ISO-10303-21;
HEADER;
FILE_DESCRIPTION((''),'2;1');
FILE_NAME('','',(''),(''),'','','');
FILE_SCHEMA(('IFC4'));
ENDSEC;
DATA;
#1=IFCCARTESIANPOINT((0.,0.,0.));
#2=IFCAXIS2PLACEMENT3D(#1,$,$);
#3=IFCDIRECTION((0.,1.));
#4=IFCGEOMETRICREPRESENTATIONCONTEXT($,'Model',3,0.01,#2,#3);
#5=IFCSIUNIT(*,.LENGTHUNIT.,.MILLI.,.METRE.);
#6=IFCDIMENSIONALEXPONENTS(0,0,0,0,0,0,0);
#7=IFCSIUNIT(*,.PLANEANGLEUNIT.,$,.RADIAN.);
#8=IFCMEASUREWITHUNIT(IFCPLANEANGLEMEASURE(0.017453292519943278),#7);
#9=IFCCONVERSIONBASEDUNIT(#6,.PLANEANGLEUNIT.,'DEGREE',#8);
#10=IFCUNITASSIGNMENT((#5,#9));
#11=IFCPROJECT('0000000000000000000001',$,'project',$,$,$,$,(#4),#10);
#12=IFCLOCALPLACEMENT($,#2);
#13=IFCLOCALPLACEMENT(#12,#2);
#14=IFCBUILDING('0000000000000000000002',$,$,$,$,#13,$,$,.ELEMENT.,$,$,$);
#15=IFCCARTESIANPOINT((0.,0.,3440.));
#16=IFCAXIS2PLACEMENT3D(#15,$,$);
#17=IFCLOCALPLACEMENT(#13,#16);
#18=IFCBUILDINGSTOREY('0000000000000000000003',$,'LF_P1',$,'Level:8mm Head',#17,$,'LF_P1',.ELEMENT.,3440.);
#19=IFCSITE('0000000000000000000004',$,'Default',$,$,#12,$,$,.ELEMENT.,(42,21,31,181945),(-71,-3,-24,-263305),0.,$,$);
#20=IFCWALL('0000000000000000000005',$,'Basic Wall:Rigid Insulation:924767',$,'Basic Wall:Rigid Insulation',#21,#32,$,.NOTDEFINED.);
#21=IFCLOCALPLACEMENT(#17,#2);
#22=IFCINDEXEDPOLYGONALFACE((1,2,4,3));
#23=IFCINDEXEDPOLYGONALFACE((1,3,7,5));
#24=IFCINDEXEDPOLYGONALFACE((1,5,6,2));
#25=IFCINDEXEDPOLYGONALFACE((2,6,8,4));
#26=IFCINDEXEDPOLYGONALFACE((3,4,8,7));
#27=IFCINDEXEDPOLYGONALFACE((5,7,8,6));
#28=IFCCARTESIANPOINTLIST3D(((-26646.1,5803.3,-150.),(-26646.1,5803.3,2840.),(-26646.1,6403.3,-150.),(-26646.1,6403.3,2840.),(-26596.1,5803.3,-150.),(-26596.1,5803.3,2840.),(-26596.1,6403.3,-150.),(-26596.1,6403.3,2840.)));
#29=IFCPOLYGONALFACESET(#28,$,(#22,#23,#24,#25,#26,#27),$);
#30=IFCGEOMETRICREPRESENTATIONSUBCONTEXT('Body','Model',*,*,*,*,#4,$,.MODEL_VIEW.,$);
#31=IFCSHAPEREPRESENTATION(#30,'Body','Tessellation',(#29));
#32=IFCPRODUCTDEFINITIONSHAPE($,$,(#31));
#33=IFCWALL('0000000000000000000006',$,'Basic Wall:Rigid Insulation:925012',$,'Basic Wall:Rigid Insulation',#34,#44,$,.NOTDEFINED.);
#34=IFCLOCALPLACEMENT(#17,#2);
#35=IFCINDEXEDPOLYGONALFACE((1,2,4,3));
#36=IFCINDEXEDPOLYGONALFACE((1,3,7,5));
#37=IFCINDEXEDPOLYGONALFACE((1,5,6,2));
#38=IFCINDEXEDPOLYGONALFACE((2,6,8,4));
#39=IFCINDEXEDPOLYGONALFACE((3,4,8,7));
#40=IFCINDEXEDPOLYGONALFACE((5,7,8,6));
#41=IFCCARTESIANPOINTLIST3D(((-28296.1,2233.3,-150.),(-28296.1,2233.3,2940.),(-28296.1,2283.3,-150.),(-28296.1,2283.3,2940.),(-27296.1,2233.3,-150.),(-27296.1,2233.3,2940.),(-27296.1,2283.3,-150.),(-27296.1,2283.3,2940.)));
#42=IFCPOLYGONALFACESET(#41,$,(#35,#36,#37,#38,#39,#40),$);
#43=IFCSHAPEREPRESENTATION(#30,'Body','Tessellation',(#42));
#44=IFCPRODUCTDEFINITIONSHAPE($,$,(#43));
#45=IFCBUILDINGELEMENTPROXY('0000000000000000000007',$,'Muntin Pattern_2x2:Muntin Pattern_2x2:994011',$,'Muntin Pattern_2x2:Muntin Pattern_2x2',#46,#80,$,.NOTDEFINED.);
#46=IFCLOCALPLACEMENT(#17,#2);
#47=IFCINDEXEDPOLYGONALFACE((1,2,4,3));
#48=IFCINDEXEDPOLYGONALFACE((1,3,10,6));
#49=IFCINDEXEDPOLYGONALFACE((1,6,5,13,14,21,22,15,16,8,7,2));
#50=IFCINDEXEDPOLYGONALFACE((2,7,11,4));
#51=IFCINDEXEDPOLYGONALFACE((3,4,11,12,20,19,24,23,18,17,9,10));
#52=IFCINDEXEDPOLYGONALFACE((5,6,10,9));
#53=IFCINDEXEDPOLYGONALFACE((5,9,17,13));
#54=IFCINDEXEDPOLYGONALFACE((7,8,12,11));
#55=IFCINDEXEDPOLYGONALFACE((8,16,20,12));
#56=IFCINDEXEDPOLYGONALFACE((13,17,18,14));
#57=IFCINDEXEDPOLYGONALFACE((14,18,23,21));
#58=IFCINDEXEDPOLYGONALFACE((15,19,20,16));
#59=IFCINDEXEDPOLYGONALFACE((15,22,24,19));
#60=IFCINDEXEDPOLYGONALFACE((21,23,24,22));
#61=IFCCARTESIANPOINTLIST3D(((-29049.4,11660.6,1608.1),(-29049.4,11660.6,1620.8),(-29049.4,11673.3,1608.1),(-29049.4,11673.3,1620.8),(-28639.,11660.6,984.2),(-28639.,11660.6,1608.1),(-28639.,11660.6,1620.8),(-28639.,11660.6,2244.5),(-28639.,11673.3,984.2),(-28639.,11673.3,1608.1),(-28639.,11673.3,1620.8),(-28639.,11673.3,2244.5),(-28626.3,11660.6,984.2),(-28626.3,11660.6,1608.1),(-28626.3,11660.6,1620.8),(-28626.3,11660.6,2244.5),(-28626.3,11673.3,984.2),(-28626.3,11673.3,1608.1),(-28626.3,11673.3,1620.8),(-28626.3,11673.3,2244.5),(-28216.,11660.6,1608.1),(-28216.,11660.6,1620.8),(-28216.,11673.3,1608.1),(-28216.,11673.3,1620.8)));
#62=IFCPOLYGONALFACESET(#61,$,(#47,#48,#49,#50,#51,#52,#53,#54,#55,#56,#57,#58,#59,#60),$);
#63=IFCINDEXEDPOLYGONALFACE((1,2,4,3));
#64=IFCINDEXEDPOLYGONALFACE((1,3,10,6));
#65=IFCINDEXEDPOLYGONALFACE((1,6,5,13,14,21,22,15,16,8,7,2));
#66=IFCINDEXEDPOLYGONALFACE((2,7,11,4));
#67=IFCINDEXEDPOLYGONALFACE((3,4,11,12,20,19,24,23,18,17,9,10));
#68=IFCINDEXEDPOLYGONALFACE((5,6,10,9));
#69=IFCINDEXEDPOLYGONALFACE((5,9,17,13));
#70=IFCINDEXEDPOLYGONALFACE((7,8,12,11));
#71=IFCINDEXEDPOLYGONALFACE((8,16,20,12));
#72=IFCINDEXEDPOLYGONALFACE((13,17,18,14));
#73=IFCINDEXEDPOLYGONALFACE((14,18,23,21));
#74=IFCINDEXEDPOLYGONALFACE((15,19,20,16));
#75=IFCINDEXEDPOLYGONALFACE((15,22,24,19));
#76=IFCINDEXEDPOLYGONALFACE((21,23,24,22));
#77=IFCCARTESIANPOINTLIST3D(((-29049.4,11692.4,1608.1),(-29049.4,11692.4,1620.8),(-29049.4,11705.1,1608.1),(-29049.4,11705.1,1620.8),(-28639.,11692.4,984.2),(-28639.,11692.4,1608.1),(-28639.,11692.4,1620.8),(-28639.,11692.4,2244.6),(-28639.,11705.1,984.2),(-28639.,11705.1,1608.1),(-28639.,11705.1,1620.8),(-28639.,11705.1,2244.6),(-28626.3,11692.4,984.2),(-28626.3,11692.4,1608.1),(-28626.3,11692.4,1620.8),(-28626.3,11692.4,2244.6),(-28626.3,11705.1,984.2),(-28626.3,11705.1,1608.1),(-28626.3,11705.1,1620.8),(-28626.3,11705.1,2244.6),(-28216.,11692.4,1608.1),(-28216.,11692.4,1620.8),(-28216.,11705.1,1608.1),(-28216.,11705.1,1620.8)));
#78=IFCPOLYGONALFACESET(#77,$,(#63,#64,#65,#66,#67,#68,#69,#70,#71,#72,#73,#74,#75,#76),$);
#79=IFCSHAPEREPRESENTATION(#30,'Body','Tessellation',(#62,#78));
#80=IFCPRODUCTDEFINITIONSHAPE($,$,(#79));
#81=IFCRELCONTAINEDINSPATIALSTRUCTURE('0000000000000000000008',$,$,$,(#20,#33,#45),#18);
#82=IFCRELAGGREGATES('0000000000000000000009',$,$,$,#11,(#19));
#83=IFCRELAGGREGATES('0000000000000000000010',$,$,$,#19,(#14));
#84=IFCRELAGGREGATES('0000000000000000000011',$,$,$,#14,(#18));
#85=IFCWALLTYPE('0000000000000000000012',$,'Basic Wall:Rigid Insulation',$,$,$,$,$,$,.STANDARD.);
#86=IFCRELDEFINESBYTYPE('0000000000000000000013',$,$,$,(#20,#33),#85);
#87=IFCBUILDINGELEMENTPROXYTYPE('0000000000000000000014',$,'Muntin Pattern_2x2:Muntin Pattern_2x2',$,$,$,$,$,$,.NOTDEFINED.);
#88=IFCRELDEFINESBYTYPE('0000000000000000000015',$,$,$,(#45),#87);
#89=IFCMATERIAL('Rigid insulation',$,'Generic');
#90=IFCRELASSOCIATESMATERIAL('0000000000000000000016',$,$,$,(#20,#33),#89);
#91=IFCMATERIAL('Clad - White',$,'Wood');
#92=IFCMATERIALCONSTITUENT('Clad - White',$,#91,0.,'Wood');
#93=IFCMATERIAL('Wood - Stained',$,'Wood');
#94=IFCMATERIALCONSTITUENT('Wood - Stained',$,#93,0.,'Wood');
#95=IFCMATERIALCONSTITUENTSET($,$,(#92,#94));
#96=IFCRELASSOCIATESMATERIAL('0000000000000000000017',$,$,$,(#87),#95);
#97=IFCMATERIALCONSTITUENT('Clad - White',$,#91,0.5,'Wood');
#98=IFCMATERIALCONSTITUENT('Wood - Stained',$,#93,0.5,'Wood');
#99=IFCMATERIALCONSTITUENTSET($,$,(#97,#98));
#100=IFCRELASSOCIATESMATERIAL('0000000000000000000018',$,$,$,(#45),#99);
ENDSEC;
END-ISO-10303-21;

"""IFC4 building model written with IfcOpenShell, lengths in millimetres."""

from ifc_helpers import new_model, entity, si_unit, converted_unit, direction, frame, origin, place, context, subcontext, project, spatial, indexed_curve, outline, extrude, source, transform, mapped, material, constituent, constituent_set, type_object, type_shapes, element, save


model = new_model("IFC4")

# Units and contexts
model_context = context("Model", 3, precision=0.01, world=origin(), true_north=direction((0.0, 1.0)))
body_context = subcontext(model_context, "Body", "Model", "MODEL_VIEW")
ifc_project = project(units=[si_unit("LENGTHUNIT", "METRE", prefix="MILLI"), converted_unit("PLANEANGLEUNIT", "DEGREE", entity("IfcPlaneAngleMeasure", 0.017453292519943278), si_unit("PLANEANGLEUNIT", "RADIAN"), dimensions=[0, 0, 0, 0, 0, 0, 0])], contexts=[model_context])

# Site, building, storey
site_placement = place(None, origin())
site = spatial("IfcSite", under=ifc_project, at=site_placement, Name="Default", CompositionType="ELEMENT", RefLatitude=(42, 21, 31, 181945), RefLongitude=(-71, -3, -24, -263305), RefElevation=0.0)
building_placement = place(site_placement, origin())
building = spatial("IfcBuilding", under=site, at=building_placement, CompositionType="ELEMENT")
storey_placement = place(building_placement, frame((0.0, 0.0, 3440.0)))
storey = spatial("IfcBuildingStorey", under=building, at=storey_placement, Name="LF_P1", ObjectType="Level:8mm Head", LongName="LF_P1", CompositionType="ELEMENT", Elevation=3440.0)

# Walls
ifc_material_1 = material(Name="Rigid insulation", Category="Generic")
wall_type_1 = type_object("IfcWallType", Name="Basic Wall:Rigid Insulation", PredefinedType="STANDARD")
wall_1_placement = place(storey_placement, frame((-26621.1, 6403.3, -150.0), z_axis=(0.0, 0.0, 1.0), x_axis=(0.0, -1.0, 0.0)))
element("IfcWall", 1, at=wall_1_placement, inside=storey, type_object=wall_type_1, material=ifc_material_1, Name="Basic Wall:Rigid Insulation:924767", ObjectType="Basic Wall:Rigid Insulation", PredefinedType="NOTDEFINED", context=body_context, shape_type="SweptSolid", body=[
    extrude(outline(indexed_curve([(600.0, 25.0), (0.0, 25.0), (0.0, -25.0), (600.0, -25.0), (600.0, 25.0)], self_intersect=False)), origin(), (0.0, 0.0, 1.0), 2990.0),
])
wall_2_placement = place(storey_placement, frame((-27296.1, 2258.3, -150.0), z_axis=(0.0, 0.0, 1.0), x_axis=(-1.0, 0.0, 0.0)))
element("IfcWall", 2, at=wall_2_placement, inside=storey, type_object=wall_type_1, material=ifc_material_1, Name="Basic Wall:Rigid Insulation:925012", ObjectType="Basic Wall:Rigid Insulation", PredefinedType="NOTDEFINED", context=body_context, shape_type="SweptSolid", body=[
    extrude(outline(indexed_curve([(1000.0, 25.0), (0.0, 25.0), (0.0, -25.0), (1000.0, -25.0), (1000.0, 25.0)], self_intersect=False)), origin(), (0.0, 0.0, 1.0), 3090.0),
])

# Building element proxy
ifc_material_2 = material(Name="Clad - White", Category="Wood")
ifc_constituent_1 = constituent(ifc_material_2, Name="Clad - White", Category="Wood", fraction=0.5)
ifc_material_3 = material(Name="Wood - Stained", Category="Wood")
ifc_constituent_2 = constituent(ifc_material_3, Name="Wood - Stained", Category="Wood", fraction=0.5)
ifc_constituent_set_1 = constituent_set(constituents=[ifc_constituent_1, ifc_constituent_2])
ifc_constituent_3 = constituent(ifc_material_2, Name="Clad - White", Category="Wood", fraction=0.0)
ifc_constituent_4 = constituent(ifc_material_3, Name="Wood - Stained", Category="Wood", fraction=0.0)
ifc_constituent_set_2 = constituent_set(constituents=[ifc_constituent_3, ifc_constituent_4])
building_element_proxy_type = type_object("IfcBuildingElementProxyType", Name="Muntin Pattern_2x2:Muntin Pattern_2x2", PredefinedType="NOTDEFINED", material=ifc_constituent_set_2)
shared_shape_1 = source(origin(), body_context, "Body", "SweptSolid", [
    extrude(outline(indexed_curve([(6.4, -6.4), (630.1, -6.4), (630.1, 6.3), (6.4, 6.3), (6.4, 416.7), (-6.3, 416.7), (-6.3, 6.3), (-630.2, 6.3), (-630.2, -6.4), (-6.3, -6.4), (-6.3, -416.7), (6.4, -416.7), (6.4, -6.4)], self_intersect=False)), frame((0.0, 9.5, 630.1), z_axis=(0.0, 1.0, 0.0), x_axis=(0.0, 0.0, 1.0)), (0.0, 0.0, 1.0), 12.7),
    extrude(outline(indexed_curve([(6.4, -6.4), (630.2, -6.4), (630.2, 6.3), (6.4, 6.3), (6.4, 416.7), (-6.3, 416.7), (-6.3, 6.3), (-630.2, 6.3), (-630.2, -6.4), (-6.3, -6.4), (-6.3, -416.7), (6.4, -416.7), (6.4, -6.4)], self_intersect=False)), frame((0.0, -22.2, 630.2), z_axis=(0.0, 1.0, 0.0), x_axis=(0.0, 0.0, 1.0)), (0.0, 0.0, 1.0), 12.7),
])
type_shapes(building_element_proxy_type, [shared_shape_1])
proxy_placement = place(storey_placement, frame((-28632.7, 11682.9, 984.3), z_axis=(0.0, 0.0, 1.0), x_axis=(-1.0, 0.0, 0.0)))
element("IfcBuildingElementProxy", 3, at=proxy_placement, inside=storey, type_object=building_element_proxy_type, material=ifc_constituent_set_1, Name="Muntin Pattern_2x2:Muntin Pattern_2x2:994011", ObjectType="Muntin Pattern_2x2:Muntin Pattern_2x2", PredefinedType="NOTDEFINED", context=body_context, shape_type="MappedRepresentation", body=[
    mapped(shared_shape_1, transform((0.0, 0.0, 0.0), scale=1.0)),
])

save(model, "model.ifc")
